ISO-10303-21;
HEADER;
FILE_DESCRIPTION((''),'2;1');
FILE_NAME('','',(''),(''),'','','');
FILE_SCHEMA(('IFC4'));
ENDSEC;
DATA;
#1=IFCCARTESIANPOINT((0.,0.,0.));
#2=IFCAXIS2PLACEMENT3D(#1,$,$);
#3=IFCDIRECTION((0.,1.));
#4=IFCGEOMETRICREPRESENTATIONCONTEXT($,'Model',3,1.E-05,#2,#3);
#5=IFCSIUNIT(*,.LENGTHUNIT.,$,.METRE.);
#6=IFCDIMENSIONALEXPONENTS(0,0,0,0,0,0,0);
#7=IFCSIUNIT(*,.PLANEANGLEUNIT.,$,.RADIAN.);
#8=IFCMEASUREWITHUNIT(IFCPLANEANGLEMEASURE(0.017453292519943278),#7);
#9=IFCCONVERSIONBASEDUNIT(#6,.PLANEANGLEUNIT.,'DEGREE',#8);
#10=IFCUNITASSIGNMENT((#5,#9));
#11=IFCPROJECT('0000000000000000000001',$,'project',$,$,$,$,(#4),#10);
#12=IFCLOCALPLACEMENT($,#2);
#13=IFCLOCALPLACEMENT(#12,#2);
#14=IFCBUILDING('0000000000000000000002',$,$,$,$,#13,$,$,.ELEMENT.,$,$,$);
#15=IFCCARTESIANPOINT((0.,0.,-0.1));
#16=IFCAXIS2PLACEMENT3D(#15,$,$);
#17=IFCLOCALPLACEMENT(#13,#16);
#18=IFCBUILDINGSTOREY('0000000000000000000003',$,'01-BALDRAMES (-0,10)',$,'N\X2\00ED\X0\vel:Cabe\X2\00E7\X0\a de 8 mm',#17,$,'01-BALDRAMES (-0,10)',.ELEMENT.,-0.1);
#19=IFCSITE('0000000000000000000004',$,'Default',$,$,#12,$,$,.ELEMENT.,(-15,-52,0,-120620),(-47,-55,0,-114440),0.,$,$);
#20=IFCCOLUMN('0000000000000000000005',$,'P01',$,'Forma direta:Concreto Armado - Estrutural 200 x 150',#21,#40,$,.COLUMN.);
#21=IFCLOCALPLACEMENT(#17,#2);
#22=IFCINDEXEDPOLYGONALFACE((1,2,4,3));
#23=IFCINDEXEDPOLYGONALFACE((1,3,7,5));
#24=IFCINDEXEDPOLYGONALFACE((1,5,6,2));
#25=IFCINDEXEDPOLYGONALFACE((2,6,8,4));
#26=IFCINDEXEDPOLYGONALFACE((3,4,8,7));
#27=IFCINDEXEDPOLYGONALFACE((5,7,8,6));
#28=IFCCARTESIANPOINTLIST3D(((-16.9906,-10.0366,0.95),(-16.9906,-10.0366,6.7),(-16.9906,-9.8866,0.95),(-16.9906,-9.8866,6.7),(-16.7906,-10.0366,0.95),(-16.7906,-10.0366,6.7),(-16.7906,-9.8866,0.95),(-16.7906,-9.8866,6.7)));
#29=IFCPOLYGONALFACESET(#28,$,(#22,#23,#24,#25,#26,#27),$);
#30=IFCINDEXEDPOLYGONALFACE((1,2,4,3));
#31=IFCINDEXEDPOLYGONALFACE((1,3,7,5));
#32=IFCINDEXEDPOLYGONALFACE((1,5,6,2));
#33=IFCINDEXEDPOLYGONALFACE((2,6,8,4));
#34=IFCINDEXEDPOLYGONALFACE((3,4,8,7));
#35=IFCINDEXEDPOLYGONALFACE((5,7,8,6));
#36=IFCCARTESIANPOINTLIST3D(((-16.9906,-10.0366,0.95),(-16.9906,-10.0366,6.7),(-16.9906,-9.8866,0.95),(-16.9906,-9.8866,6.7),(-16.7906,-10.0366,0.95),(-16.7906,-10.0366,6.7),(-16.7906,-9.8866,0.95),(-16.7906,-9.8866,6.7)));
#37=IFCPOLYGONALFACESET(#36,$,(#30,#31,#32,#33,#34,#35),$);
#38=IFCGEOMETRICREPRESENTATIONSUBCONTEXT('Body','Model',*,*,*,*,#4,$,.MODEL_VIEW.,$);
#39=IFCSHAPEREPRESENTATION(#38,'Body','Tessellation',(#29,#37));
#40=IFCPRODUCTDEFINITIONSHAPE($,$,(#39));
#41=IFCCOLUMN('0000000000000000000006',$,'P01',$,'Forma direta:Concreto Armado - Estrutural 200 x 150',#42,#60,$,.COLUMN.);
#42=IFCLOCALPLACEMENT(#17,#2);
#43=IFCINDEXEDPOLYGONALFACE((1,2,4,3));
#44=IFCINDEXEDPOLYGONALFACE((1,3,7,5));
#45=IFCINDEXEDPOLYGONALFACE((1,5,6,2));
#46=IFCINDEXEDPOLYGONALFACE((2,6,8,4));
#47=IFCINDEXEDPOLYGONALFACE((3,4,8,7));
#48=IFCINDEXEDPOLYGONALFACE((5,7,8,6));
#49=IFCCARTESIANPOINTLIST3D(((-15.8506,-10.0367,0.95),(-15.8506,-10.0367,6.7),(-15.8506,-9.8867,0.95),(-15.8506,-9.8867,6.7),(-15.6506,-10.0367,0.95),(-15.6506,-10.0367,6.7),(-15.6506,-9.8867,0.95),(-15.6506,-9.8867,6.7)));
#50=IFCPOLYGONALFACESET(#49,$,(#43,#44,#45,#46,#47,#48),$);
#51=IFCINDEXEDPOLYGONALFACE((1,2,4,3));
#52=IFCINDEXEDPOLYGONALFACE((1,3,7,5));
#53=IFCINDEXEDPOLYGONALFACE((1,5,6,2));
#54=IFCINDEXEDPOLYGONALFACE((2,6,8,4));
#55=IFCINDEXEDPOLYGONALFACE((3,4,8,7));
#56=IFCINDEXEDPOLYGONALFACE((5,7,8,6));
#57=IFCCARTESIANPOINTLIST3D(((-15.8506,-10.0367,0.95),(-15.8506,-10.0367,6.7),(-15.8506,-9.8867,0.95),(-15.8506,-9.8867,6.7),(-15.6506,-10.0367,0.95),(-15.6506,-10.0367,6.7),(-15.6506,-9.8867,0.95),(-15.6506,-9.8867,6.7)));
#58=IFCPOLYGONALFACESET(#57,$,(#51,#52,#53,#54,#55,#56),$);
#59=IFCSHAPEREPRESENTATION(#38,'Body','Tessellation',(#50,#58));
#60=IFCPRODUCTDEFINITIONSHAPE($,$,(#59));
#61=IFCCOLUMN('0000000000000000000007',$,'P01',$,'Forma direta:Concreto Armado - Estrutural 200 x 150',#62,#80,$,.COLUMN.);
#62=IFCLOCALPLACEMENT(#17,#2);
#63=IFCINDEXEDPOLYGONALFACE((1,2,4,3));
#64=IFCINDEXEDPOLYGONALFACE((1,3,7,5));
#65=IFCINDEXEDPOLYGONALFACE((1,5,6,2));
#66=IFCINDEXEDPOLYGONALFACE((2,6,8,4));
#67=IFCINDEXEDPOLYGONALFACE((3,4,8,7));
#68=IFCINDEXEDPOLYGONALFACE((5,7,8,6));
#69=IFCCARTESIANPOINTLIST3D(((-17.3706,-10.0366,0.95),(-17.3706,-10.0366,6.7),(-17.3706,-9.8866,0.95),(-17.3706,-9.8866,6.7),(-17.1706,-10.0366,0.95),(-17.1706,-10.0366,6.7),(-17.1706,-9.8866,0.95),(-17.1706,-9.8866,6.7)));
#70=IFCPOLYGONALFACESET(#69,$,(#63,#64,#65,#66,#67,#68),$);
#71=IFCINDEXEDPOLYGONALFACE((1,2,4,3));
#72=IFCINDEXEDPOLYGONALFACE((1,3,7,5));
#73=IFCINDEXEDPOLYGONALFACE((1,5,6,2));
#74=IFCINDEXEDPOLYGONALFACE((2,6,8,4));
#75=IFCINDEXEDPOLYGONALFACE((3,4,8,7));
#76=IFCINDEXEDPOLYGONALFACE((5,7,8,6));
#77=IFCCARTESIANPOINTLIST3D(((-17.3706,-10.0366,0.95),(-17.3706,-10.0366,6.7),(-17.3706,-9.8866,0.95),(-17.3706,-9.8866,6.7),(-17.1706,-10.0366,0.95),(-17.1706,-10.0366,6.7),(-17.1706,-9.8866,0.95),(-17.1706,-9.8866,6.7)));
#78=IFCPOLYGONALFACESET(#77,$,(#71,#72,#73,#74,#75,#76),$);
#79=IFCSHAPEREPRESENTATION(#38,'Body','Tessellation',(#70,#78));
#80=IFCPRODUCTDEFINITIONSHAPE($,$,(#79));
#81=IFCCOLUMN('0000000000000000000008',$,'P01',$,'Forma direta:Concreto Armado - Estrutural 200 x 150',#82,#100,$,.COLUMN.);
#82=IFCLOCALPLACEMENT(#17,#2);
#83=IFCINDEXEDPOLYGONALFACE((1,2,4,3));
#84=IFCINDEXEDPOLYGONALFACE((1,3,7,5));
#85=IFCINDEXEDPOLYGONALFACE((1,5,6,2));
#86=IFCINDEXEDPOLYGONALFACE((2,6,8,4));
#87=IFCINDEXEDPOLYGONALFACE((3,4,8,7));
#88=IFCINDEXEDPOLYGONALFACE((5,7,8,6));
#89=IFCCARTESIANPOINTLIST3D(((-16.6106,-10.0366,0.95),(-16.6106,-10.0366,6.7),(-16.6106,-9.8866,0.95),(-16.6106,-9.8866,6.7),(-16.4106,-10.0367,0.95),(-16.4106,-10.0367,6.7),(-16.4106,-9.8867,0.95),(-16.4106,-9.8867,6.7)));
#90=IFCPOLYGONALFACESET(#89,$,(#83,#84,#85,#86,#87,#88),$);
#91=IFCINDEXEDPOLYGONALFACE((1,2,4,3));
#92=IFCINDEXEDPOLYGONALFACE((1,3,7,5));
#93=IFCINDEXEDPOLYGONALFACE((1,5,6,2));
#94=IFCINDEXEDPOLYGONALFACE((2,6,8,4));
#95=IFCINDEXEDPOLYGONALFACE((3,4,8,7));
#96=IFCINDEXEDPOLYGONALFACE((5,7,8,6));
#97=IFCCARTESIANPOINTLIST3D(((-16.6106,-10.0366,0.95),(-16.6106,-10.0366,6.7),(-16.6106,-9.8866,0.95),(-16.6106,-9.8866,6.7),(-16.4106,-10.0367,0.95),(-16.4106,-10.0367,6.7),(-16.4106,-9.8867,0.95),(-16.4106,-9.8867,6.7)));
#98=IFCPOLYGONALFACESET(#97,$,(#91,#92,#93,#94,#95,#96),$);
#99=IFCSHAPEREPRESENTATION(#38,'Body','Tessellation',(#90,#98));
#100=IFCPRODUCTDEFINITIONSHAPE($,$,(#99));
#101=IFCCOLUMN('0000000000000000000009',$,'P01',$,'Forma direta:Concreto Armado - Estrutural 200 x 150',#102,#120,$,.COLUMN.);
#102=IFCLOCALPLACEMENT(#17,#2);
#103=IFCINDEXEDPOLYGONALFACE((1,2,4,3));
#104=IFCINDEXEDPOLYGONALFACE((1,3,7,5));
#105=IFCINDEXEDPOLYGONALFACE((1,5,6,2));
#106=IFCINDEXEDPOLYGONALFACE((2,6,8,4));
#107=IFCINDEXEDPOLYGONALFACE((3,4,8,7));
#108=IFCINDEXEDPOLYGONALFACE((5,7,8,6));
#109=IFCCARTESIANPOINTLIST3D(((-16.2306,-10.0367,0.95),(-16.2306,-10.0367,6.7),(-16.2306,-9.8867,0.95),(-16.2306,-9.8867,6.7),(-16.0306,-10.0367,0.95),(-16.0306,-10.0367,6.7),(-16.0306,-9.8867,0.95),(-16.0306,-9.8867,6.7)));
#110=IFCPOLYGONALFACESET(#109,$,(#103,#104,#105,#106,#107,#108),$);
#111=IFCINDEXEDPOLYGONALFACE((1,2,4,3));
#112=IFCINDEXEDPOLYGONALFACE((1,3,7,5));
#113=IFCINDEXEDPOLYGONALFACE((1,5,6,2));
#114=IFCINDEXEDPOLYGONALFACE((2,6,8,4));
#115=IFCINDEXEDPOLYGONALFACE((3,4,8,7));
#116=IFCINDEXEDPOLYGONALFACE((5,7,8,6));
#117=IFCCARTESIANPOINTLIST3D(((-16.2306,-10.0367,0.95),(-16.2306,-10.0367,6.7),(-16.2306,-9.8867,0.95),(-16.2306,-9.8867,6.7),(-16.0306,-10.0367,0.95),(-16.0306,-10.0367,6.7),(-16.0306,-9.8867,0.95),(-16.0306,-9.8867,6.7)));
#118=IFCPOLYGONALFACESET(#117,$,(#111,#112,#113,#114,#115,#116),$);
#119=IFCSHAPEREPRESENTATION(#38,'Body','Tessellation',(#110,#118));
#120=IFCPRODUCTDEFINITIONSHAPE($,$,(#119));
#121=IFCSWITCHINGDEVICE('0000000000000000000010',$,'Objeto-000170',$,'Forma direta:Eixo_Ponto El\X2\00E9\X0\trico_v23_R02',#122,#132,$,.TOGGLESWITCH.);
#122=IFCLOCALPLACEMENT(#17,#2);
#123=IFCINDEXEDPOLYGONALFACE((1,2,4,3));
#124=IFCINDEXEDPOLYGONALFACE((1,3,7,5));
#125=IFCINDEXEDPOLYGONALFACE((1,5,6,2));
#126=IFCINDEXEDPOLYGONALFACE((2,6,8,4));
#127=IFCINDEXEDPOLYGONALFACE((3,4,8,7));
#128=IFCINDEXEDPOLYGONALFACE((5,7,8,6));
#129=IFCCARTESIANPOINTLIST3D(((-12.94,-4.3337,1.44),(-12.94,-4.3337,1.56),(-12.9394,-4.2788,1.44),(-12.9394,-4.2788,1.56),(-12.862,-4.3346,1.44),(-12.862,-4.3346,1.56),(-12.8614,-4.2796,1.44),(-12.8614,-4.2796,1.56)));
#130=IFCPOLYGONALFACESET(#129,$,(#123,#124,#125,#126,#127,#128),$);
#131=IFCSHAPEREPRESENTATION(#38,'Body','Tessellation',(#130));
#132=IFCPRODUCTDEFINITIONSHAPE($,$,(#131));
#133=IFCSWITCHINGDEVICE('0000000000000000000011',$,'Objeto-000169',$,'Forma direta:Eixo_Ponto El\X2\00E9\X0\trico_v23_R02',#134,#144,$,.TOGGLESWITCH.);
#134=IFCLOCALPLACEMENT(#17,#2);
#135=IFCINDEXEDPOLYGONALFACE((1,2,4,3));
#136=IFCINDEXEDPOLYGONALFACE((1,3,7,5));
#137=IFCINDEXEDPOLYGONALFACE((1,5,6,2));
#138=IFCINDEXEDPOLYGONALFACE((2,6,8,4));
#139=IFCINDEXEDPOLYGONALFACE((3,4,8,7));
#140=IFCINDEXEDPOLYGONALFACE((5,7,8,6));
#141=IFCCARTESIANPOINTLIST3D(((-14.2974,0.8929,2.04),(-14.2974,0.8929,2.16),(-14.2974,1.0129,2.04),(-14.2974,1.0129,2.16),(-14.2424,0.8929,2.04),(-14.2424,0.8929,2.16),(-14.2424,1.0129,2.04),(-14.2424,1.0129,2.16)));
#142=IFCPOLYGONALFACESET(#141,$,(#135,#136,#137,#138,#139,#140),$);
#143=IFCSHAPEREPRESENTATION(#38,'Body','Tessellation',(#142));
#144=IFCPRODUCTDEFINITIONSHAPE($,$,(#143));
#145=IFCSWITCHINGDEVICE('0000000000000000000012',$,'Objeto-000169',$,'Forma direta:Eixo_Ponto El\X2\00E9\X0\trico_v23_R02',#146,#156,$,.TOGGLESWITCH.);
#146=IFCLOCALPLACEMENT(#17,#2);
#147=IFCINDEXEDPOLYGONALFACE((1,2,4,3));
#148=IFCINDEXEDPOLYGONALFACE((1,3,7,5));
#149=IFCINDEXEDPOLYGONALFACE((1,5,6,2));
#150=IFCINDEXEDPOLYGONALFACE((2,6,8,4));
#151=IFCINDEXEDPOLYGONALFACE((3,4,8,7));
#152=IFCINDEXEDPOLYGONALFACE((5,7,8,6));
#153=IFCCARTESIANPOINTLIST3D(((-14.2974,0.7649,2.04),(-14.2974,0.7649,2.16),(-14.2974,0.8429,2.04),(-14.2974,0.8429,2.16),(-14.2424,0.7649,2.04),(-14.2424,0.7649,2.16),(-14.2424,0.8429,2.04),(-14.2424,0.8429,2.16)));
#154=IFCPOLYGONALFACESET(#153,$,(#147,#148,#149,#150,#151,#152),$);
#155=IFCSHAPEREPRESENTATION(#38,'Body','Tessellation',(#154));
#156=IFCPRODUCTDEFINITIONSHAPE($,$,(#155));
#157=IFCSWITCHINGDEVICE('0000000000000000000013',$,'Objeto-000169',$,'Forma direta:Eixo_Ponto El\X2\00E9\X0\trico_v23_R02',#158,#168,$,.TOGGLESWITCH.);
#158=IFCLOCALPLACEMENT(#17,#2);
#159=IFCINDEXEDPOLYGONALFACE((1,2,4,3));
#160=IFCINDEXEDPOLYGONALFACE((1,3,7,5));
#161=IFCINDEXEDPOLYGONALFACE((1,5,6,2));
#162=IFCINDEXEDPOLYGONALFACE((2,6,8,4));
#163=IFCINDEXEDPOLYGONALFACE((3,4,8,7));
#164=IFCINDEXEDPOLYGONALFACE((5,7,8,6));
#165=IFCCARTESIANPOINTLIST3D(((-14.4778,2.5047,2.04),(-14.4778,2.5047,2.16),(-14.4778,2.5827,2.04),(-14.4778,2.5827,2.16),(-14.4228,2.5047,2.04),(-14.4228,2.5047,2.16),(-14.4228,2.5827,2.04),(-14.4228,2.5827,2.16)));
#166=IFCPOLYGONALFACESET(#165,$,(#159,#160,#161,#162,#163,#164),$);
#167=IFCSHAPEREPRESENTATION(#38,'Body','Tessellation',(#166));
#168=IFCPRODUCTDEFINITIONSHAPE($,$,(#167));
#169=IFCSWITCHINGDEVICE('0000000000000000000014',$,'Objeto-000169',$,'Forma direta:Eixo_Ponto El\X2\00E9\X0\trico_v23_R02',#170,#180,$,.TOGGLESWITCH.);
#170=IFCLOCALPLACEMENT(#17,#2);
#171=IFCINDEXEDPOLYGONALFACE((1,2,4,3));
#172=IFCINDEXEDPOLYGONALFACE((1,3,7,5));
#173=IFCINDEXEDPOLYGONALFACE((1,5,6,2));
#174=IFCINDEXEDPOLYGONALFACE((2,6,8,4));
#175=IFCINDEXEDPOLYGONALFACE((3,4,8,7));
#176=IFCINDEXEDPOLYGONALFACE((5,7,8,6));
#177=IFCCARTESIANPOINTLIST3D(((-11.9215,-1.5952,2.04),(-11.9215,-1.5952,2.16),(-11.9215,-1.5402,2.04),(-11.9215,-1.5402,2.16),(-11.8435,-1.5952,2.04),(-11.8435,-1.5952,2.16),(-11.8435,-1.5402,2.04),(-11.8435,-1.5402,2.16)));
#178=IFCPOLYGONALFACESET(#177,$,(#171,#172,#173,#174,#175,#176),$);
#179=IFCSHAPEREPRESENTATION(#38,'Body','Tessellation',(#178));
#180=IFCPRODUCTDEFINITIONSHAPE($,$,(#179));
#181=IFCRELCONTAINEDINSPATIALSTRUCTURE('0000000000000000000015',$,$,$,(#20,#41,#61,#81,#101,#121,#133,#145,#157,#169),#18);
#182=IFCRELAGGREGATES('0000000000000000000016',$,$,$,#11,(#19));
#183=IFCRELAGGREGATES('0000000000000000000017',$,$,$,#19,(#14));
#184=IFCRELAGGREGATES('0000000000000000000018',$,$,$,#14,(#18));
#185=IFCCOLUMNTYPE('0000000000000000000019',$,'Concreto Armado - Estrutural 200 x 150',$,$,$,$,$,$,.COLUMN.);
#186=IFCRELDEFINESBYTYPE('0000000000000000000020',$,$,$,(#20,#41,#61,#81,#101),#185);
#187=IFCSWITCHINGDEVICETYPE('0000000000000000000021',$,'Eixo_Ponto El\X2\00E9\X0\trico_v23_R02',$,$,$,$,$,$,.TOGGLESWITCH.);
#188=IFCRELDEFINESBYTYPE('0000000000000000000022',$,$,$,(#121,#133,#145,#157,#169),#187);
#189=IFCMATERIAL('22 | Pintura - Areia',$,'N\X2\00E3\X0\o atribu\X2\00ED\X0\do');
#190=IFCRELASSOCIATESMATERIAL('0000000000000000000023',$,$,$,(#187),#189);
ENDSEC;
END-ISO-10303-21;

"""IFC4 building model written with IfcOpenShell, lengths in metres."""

from ifc_helpers import new_model, entity, si_unit, converted_unit, direction, frame, origin, place, context, subcontext, project, spatial, indexed_curve, outline, extrude, material, type_object, element, save


model = new_model("IFC4")

# Units and contexts
model_context = context("Model", 3, precision=1e-05, world=origin(), true_north=direction((0.0, 1.0)))
body_context = subcontext(model_context, "Body", "Model", "MODEL_VIEW")
ifc_project = project(units=[si_unit("LENGTHUNIT", "METRE"), converted_unit("PLANEANGLEUNIT", "DEGREE", entity("IfcPlaneAngleMeasure", 0.017453292519943278), si_unit("PLANEANGLEUNIT", "RADIAN"), dimensions=[0, 0, 0, 0, 0, 0, 0])], contexts=[model_context])

# Site, building, storey
site_placement = place(None, origin())
site = spatial("IfcSite", under=ifc_project, at=site_placement, Name="Default", CompositionType="ELEMENT", RefLatitude=(-15, -52, 0, -120620), RefLongitude=(-47, -55, 0, -114440), RefElevation=0.0)
building_placement = place(site_placement, origin())
building = spatial("IfcBuilding", under=site, at=building_placement, CompositionType="ELEMENT")
storey_placement = place(building_placement, frame((0.0, 0.0, -0.1)))
storey = spatial("IfcBuildingStorey", under=building, at=storey_placement, Name="01-BALDRAMES (-0,10)", ObjectType="Nível:Cabeça de 8 mm", LongName="01-BALDRAMES (-0,10)", CompositionType="ELEMENT", Elevation=-0.1)

# Columns
column_type = type_object("IfcColumnType", Name="Concreto Armado - Estrutural 200 x 150", PredefinedType="COLUMN")
column_1_placement = place(storey_placement, origin())
element("IfcColumn", 1, at=column_1_placement, inside=storey, type_object=column_type, Name="P01", ObjectType="Forma direta:Concreto Armado - Estrutural 200 x 150", PredefinedType="COLUMN", context=body_context, shape_type="SweptSolid", body=[
    extrude(outline(indexed_curve([(-0.075, -0.1), (0.075, -0.1), (0.075, 0.1), (-0.075, 0.1), (-0.075, -0.1)], self_intersect=False)), frame((-16.8906, -9.9616, 0.95), z_axis=(0.0, 0.0, 1.0), x_axis=(-0.000013, -1.0, 0.0)), (0.0, 0.0, 1.0), 5.75),
    extrude(outline(indexed_curve([(-0.075, -0.1), (0.075, -0.1), (0.075, 0.1), (-0.075, 0.1), (-0.075, -0.1)], self_intersect=False)), frame((-16.8906, -9.9616, 0.95), z_axis=(0.0, 0.0, 1.0), x_axis=(-0.000013, -1.0, 0.0)), (0.0, 0.0, 1.0), 5.75),
])
column_2_placement = place(storey_placement, origin())
element("IfcColumn", 2, at=column_2_placement, inside=storey, type_object=column_type, Name="P01", ObjectType="Forma direta:Concreto Armado - Estrutural 200 x 150", PredefinedType="COLUMN", context=body_context, shape_type="SweptSolid", body=[
    extrude(outline(indexed_curve([(-0.075, -0.1), (0.075, -0.1), (0.075, 0.1), (-0.075, 0.1), (-0.075, -0.1)], self_intersect=False)), frame((-15.7506, -9.9617, 0.95), z_axis=(0.0, 0.0, 1.0), x_axis=(-0.000013, -1.0, 0.0)), (0.0, 0.0, 1.0), 5.75),
    extrude(outline(indexed_curve([(-0.075, -0.1), (0.075, -0.1), (0.075, 0.1), (-0.075, 0.1), (-0.075, -0.1)], self_intersect=False)), frame((-15.7506, -9.9617, 0.95), z_axis=(0.0, 0.0, 1.0), x_axis=(-0.000013, -1.0, 0.0)), (0.0, 0.0, 1.0), 5.75),
])
column_3_placement = place(storey_placement, origin())
element("IfcColumn", 3, at=column_3_placement, inside=storey, type_object=column_type, Name="P01", ObjectType="Forma direta:Concreto Armado - Estrutural 200 x 150", PredefinedType="COLUMN", context=body_context, shape_type="SweptSolid", body=[
    extrude(outline(indexed_curve([(-0.075, -0.1), (0.075, -0.1), (0.075, 0.1), (-0.075, 0.1), (-0.075, -0.1)], self_intersect=False)), frame((-17.2706, -9.9616, 0.95), z_axis=(0.0, 0.0, 1.0), x_axis=(-0.000013, -1.0, 0.0)), (0.0, 0.0, 1.0), 5.75),
    extrude(outline(indexed_curve([(-0.075, -0.1), (0.075, -0.1), (0.075, 0.1), (-0.075, 0.1), (-0.075, -0.1)], self_intersect=False)), frame((-17.2706, -9.9616, 0.95), z_axis=(0.0, 0.0, 1.0), x_axis=(-0.000013, -1.0, 0.0)), (0.0, 0.0, 1.0), 5.75),
])
column_4_placement = place(storey_placement, origin())
element("IfcColumn", 4, at=column_4_placement, inside=storey, type_object=column_type, Name="P01", ObjectType="Forma direta:Concreto Armado - Estrutural 200 x 150", PredefinedType="COLUMN", context=body_context, shape_type="SweptSolid", body=[
    extrude(outline(indexed_curve([(-0.075, -0.1), (0.075, -0.1), (0.075, 0.1), (-0.075, 0.1), (-0.075, -0.1)], self_intersect=False)), frame((-16.5106, -9.9617, 0.95), z_axis=(0.0, 0.0, 1.0), x_axis=(-0.000013, -1.0, 0.0)), (0.0, 0.0, 1.0), 5.75),
    extrude(outline(indexed_curve([(-0.075, -0.1), (0.075, -0.1), (0.075, 0.1), (-0.075, 0.1), (-0.075, -0.1)], self_intersect=False)), frame((-16.5106, -9.9617, 0.95), z_axis=(0.0, 0.0, 1.0), x_axis=(-0.000013, -1.0, 0.0)), (0.0, 0.0, 1.0), 5.75),
])
column_5_placement = place(storey_placement, origin())
element("IfcColumn", 5, at=column_5_placement, inside=storey, type_object=column_type, Name="P01", ObjectType="Forma direta:Concreto Armado - Estrutural 200 x 150", PredefinedType="COLUMN", context=body_context, shape_type="SweptSolid", body=[
    extrude(outline(indexed_curve([(-0.075, -0.1), (0.075, -0.1), (0.075, 0.1), (-0.075, 0.1), (-0.075, -0.1)], self_intersect=False)), frame((-16.1306, -9.9617, 0.95), z_axis=(0.0, 0.0, 1.0), x_axis=(-0.000013, -1.0, 0.0)), (0.0, 0.0, 1.0), 5.75),
    extrude(outline(indexed_curve([(-0.075, -0.1), (0.075, -0.1), (0.075, 0.1), (-0.075, 0.1), (-0.075, -0.1)], self_intersect=False)), frame((-16.1306, -9.9617, 0.95), z_axis=(0.0, 0.0, 1.0), x_axis=(-0.000013, -1.0, 0.0)), (0.0, 0.0, 1.0), 5.75),
])

# Switching devices
ifc_material_1 = material(Name="22 | Pintura - Areia", Category="Não atribuído")
switching_device_type_1 = type_object("IfcSwitchingDeviceType", Name="Eixo_Ponto Elétrico_v23_R02", PredefinedType="TOGGLESWITCH", material=ifc_material_1)
switching_device_1_placement = place(storey_placement, origin())
element("IfcSwitchingDevice", 6, at=switching_device_1_placement, inside=storey, type_object=switching_device_type_1, Name="Objeto-000170", ObjectType="Forma direta:Eixo_Ponto Elétrico_v23_R02", PredefinedType="TOGGLESWITCH", context=body_context, shape_type="SweptSolid", body=[
    extrude(outline(indexed_curve([(-0.0275, -0.039), (0.0275, -0.039), (0.0275, 0.039), (-0.0275, 0.039), (-0.0275, -0.039)], self_intersect=False)), frame((-12.9007, -4.3067, 1.44), z_axis=(0.0, 0.0, 1.0), x_axis=(-0.011486, -0.999934, 0.0)), (0.0, 0.0, 1.0), 0.12),
])
switching_device_2_placement = place(storey_placement, origin())
element("IfcSwitchingDevice", 7, at=switching_device_2_placement, inside=storey, type_object=switching_device_type_1, Name="Objeto-000169", ObjectType="Forma direta:Eixo_Ponto Elétrico_v23_R02", PredefinedType="TOGGLESWITCH", context=body_context, shape_type="SweptSolid", body=[
    extrude(outline(indexed_curve([(-0.0275, -0.06), (0.0275, -0.06), (0.0275, 0.06), (-0.0275, 0.06), (-0.0275, -0.06)], self_intersect=False)), frame((-14.2699, 0.9529, 2.04), z_axis=(0.0, 0.0, 1.0), x_axis=(-1.0, 0.00001, 0.0)), (0.0, 0.0, 1.0), 0.12),
])
switching_device_3_placement = place(storey_placement, origin())
element("IfcSwitchingDevice", 8, at=switching_device_3_placement, inside=storey, type_object=switching_device_type_1, Name="Objeto-000169", ObjectType="Forma direta:Eixo_Ponto Elétrico_v23_R02", PredefinedType="TOGGLESWITCH", context=body_context, shape_type="SweptSolid", body=[
    extrude(outline(indexed_curve([(-0.039, -0.0275), (0.039, -0.0275), (0.039, 0.0275), (-0.039, 0.0275), (-0.039, -0.0275)], self_intersect=False)), frame((-14.2699, 0.8039, 2.04), z_axis=(0.0, 0.0, 1.0), x_axis=(0.000016, 1.0, 0.0)), (0.0, 0.0, 1.0), 0.12),
])
switching_device_4_placement = place(storey_placement, origin())
element("IfcSwitchingDevice", 9, at=switching_device_4_placement, inside=storey, type_object=switching_device_type_1, Name="Objeto-000169", ObjectType="Forma direta:Eixo_Ponto Elétrico_v23_R02", PredefinedType="TOGGLESWITCH", context=body_context, shape_type="SweptSolid", body=[
    extrude(outline(indexed_curve([(-0.0275, -0.039), (0.0275, -0.039), (0.0275, 0.039), (-0.0275, 0.039), (-0.0275, -0.039)], self_intersect=False)), frame((-14.4503, 2.5437, 2.04)), (0.0, 0.0, 1.0), 0.12),
])
switching_device_5_placement = place(storey_placement, origin())
element("IfcSwitchingDevice", 10, at=switching_device_5_placement, inside=storey, type_object=switching_device_type_1, Name="Objeto-000169", ObjectType="Forma direta:Eixo_Ponto Elétrico_v23_R02", PredefinedType="TOGGLESWITCH", context=body_context, shape_type="SweptSolid", body=[
    extrude(outline(indexed_curve([(-0.0275, -0.039), (0.0275, -0.039), (0.0275, 0.039), (-0.0275, 0.039), (-0.0275, -0.039)], self_intersect=False)), frame((-11.8825, -1.5677, 2.04), z_axis=(0.0, 0.0, 1.0), x_axis=(0.000013, 1.0, 0.0)), (0.0, 0.0, 1.0), 0.12),
])

save(model, "model.ifc")
